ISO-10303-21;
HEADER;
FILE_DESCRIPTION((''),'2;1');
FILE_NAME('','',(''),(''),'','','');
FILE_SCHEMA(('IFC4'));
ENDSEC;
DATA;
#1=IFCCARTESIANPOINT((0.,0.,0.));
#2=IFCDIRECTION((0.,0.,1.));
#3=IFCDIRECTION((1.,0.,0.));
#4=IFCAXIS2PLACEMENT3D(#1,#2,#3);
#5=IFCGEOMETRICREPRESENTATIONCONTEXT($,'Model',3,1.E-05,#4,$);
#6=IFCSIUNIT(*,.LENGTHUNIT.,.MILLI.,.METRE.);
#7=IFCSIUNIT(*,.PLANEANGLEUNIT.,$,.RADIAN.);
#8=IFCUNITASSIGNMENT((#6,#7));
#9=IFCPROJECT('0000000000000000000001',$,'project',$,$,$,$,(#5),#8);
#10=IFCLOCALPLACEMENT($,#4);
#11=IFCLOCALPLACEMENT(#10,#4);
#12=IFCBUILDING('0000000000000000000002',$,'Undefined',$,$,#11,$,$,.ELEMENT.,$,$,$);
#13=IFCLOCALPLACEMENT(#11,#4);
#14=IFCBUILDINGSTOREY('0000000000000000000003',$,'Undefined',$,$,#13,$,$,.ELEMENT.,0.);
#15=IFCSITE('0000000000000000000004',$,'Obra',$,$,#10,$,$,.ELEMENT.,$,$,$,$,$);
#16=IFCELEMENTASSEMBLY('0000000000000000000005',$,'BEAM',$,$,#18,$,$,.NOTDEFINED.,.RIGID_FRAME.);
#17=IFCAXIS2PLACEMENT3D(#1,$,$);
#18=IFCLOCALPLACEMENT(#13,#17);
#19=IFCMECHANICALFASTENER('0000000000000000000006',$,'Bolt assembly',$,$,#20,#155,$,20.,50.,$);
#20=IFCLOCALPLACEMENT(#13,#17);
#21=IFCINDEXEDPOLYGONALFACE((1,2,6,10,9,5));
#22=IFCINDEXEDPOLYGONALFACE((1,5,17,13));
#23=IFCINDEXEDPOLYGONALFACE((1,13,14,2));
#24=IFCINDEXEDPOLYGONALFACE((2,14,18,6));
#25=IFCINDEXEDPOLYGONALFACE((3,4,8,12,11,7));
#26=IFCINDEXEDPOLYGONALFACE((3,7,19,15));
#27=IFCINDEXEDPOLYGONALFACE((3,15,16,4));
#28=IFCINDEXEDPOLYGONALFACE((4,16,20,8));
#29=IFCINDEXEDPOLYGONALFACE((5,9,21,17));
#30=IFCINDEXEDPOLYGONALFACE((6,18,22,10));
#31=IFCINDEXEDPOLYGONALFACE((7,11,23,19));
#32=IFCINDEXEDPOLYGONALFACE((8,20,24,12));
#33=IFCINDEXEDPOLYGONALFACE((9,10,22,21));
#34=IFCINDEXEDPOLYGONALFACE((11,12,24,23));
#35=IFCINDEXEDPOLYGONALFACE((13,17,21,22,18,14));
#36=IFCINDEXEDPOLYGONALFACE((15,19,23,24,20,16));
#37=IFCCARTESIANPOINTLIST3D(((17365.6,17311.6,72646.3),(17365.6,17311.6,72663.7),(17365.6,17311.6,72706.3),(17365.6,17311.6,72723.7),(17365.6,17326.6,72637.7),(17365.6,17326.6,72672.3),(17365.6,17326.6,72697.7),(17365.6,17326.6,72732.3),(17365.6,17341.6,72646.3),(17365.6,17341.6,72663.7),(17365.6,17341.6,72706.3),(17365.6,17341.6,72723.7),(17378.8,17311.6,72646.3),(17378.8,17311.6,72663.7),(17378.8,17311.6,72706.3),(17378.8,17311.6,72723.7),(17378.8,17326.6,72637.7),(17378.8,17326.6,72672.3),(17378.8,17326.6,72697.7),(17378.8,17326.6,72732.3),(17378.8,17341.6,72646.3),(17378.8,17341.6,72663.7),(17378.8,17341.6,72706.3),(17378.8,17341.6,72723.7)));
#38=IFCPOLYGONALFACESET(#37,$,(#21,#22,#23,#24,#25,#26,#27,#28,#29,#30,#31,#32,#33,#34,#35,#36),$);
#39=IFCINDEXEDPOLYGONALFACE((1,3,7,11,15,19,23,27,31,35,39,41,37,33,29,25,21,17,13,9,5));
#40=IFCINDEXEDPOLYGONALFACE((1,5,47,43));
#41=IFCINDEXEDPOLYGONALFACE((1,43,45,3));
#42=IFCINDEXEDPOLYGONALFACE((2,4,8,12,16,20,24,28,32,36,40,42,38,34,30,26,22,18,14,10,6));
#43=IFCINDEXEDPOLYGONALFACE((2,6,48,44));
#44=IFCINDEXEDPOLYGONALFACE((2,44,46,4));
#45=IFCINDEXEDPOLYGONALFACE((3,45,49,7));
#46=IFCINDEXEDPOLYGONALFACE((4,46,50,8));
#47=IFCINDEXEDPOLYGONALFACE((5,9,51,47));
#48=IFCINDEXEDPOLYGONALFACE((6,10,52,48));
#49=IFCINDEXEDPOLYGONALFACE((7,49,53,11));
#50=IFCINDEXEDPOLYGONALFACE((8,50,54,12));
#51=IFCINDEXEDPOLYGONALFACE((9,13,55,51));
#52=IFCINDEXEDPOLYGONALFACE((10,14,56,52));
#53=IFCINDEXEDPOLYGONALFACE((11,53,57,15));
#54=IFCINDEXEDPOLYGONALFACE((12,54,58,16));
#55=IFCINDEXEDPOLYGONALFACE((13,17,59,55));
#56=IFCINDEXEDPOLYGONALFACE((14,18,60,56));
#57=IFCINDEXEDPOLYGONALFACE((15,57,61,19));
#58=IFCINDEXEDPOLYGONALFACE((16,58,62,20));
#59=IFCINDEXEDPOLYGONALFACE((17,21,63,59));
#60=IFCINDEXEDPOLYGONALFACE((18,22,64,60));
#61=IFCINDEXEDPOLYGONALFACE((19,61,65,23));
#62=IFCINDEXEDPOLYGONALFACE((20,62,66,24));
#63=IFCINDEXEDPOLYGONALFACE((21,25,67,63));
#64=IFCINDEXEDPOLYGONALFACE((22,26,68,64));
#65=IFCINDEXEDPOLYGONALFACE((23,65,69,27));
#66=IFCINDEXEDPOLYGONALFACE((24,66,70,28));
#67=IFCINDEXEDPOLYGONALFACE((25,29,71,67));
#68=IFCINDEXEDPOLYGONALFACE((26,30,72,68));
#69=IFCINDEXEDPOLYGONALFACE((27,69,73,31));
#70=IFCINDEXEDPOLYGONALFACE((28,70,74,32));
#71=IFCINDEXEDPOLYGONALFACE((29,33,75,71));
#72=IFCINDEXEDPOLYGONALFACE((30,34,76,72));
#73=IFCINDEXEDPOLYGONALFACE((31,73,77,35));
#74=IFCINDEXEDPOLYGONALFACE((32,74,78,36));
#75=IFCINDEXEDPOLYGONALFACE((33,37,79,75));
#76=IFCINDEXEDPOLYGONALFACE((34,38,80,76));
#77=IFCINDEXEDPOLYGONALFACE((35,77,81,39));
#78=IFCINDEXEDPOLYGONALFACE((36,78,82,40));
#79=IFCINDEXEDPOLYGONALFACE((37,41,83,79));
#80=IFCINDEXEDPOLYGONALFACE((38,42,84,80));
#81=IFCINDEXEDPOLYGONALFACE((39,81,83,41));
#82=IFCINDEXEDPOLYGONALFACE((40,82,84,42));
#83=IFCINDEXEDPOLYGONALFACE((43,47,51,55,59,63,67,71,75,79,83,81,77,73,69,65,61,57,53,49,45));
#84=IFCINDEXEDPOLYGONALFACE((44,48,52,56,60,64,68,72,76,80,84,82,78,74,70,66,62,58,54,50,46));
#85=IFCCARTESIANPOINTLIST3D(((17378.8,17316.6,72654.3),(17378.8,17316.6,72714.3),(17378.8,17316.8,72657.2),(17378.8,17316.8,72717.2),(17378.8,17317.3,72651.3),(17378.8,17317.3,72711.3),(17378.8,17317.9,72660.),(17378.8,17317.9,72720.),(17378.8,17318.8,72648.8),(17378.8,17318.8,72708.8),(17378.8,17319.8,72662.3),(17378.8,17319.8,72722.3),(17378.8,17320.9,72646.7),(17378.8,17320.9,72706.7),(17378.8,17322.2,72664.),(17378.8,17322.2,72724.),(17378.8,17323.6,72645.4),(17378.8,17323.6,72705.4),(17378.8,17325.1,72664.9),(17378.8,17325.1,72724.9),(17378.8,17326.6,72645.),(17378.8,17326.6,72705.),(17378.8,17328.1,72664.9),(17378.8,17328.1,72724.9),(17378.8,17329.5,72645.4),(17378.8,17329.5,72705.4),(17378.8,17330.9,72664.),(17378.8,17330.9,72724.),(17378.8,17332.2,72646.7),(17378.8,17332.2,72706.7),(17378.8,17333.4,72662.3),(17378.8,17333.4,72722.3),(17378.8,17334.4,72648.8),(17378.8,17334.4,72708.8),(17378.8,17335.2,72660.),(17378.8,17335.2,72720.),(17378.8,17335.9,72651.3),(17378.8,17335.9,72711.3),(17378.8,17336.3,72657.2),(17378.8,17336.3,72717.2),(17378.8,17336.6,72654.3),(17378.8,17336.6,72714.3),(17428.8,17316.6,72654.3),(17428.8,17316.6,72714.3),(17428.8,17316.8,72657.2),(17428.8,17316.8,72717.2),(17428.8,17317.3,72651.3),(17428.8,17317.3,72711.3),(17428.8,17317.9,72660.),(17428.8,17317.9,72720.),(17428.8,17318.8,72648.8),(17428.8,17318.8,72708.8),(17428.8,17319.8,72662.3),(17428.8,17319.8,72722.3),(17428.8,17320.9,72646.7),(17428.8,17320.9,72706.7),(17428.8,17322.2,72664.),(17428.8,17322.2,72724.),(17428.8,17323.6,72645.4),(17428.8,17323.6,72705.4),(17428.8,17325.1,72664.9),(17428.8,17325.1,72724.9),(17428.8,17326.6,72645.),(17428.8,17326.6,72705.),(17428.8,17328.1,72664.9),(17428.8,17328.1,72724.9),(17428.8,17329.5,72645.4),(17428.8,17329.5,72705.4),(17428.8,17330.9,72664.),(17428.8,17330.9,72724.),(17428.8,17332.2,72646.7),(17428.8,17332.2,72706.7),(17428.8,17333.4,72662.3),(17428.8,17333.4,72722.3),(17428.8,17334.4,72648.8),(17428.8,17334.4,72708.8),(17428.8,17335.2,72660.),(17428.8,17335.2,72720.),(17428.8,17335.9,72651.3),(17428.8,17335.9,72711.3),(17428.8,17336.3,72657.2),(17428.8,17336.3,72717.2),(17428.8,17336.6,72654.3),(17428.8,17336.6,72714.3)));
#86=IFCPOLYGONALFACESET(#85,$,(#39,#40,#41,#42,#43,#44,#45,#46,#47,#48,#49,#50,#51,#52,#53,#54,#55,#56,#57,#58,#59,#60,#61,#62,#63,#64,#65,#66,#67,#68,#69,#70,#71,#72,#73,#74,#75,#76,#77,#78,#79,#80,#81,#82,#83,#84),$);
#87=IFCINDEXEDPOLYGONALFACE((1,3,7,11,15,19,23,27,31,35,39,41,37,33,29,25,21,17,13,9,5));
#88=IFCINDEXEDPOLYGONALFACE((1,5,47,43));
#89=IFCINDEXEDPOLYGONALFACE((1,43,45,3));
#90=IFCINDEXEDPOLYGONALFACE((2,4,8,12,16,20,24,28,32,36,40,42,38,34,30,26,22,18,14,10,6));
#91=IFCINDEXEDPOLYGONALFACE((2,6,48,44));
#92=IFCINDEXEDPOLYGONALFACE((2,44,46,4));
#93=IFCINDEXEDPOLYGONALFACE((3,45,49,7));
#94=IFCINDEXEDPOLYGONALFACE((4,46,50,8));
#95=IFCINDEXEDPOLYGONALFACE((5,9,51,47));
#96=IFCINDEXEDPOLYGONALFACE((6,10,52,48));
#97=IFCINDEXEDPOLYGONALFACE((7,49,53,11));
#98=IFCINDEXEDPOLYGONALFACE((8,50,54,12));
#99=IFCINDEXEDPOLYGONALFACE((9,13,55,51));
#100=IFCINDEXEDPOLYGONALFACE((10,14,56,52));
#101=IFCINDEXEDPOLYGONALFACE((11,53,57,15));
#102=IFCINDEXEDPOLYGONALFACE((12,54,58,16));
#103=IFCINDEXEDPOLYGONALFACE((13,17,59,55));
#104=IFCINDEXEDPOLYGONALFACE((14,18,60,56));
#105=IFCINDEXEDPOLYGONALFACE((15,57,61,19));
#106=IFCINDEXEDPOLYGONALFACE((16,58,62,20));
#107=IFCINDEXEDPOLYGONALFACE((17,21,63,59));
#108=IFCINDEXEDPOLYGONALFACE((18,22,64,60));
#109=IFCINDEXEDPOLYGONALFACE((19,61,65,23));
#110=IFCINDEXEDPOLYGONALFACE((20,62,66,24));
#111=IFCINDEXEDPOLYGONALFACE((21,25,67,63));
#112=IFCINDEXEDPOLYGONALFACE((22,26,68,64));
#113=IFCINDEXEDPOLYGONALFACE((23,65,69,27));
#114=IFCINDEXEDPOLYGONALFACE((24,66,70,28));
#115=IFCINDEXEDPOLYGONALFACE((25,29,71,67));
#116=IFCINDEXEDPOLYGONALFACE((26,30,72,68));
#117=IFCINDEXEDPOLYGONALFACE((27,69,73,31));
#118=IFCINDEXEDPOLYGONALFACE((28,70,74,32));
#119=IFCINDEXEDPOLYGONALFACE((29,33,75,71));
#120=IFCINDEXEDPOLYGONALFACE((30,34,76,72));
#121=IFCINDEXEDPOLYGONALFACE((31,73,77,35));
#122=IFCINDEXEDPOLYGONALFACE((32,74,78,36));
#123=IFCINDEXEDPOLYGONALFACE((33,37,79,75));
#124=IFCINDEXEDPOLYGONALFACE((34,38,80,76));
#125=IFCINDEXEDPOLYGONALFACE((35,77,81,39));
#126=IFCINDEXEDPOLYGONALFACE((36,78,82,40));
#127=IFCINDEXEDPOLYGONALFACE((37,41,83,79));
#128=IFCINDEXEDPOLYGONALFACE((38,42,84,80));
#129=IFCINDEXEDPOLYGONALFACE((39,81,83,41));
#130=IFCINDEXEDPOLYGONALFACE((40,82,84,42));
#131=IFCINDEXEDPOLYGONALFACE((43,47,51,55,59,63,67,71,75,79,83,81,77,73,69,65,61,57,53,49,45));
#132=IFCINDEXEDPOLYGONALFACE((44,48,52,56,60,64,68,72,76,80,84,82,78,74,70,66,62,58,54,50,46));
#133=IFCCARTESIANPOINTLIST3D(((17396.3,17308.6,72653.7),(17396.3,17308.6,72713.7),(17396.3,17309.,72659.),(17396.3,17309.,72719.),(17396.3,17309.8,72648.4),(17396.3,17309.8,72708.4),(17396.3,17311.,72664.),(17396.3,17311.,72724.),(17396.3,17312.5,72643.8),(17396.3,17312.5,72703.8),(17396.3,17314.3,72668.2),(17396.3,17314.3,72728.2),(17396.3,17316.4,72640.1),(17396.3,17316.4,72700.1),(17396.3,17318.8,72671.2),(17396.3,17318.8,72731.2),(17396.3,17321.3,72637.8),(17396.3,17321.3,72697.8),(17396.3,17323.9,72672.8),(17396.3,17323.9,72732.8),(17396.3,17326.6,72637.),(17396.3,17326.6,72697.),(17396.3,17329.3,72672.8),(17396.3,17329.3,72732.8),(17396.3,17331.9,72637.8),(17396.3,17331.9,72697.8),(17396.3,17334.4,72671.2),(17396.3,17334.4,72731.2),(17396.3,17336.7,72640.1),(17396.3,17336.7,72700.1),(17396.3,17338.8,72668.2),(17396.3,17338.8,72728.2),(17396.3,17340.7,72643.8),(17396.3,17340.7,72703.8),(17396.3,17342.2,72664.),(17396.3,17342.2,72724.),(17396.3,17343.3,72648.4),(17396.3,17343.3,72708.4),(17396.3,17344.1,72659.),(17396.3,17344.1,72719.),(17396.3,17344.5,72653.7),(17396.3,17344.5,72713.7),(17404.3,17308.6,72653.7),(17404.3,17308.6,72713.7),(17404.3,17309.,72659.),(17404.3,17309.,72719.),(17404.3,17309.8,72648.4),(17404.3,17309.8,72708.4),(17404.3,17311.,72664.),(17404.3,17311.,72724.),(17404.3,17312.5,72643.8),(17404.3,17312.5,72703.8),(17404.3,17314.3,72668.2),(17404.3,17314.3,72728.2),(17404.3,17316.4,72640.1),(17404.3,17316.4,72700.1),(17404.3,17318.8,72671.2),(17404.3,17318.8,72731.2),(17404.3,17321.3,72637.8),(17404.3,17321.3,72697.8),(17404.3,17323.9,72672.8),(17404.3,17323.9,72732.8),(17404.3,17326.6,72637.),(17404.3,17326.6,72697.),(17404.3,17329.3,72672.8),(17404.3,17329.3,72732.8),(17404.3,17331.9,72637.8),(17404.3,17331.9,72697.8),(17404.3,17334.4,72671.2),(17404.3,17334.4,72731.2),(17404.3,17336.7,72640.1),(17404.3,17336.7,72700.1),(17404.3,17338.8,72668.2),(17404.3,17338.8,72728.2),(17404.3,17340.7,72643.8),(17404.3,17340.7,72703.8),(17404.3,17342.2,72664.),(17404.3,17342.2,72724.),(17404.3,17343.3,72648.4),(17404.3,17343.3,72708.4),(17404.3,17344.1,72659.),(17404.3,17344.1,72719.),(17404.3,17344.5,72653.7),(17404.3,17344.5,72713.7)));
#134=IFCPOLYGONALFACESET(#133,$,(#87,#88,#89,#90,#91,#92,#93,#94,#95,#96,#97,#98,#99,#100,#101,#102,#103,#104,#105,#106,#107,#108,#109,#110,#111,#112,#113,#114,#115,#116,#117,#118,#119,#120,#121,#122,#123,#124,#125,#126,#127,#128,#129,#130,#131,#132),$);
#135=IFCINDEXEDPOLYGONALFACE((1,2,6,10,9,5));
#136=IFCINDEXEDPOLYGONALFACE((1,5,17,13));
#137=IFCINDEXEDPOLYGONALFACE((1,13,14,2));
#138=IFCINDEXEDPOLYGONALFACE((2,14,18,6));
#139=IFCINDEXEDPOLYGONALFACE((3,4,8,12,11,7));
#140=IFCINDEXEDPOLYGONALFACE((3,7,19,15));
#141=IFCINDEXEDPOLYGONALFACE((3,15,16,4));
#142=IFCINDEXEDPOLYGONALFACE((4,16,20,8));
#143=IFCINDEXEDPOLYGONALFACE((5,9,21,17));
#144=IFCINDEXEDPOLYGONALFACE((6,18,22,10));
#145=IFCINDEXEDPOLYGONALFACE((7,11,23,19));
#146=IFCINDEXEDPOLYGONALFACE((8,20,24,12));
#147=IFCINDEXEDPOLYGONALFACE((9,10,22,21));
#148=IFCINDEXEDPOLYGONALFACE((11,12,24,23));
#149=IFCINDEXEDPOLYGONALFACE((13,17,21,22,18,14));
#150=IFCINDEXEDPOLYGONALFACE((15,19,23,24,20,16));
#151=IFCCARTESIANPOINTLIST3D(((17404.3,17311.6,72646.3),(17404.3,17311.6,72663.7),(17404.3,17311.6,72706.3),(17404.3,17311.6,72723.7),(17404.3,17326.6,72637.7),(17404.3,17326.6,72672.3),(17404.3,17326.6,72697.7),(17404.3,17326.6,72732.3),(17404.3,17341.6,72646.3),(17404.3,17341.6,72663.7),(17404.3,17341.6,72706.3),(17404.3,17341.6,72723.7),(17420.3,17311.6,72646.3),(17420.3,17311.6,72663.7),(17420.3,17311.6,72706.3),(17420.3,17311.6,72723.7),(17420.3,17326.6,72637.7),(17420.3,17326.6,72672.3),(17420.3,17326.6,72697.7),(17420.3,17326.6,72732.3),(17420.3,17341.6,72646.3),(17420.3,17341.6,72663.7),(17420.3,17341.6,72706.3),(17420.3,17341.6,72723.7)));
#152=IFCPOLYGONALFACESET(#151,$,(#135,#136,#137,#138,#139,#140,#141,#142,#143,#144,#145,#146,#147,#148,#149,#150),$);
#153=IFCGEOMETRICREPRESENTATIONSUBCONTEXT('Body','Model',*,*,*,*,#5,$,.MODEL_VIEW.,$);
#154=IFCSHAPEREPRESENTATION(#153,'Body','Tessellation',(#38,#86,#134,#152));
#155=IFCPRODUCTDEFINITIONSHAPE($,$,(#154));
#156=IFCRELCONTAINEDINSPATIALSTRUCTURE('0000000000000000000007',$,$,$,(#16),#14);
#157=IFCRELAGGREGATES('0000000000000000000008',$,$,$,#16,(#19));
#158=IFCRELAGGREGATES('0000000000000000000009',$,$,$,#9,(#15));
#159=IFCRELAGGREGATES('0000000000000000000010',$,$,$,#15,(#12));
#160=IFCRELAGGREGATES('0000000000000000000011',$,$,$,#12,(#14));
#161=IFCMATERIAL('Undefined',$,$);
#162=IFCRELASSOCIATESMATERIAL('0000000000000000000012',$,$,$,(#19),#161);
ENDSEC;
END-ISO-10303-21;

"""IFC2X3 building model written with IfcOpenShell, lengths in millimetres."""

from ifc_helpers import new_model, si_unit, frame, origin_with_axes, origin_2d_with_axis, place, context, subcontext, project, spatial, polyline, circle, outline, extrude, source, transform, mapped, material, element, aggregate, save


model = new_model("IFC2X3")

# Units and contexts
model_context = context("Model", 3, precision=1e-05, world=origin_with_axes())
body_context = subcontext(model_context, "Body", "Model", "MODEL_VIEW")
ifc_project = project(units=[si_unit("LENGTHUNIT", "METRE", prefix="MILLI"), si_unit("PLANEANGLEUNIT", "RADIAN")], contexts=[model_context])

# Site, building, storey
site_placement = place(None, origin_with_axes())
site = spatial("IfcSite", under=ifc_project, at=site_placement, Name="Obra", CompositionType="ELEMENT")
building_placement = place(site_placement, origin_with_axes())
building = spatial("IfcBuilding", under=site, at=building_placement, Name="Undefined", CompositionType="ELEMENT")
storey_placement = place(building_placement, origin_with_axes())
storey = spatial("IfcBuildingStorey", under=building, at=storey_placement, Name="Undefined", CompositionType="ELEMENT", Elevation=0.0)

# Shared definitions
ifc_material = material(Name="Undefined")

# Shared definitions
shared_shape_1 = source(origin_with_axes(), body_context, "Body", "SweptSolid", [
    extrude(outline(polyline([(17.3, 0.0), (8.7, 15.0), (-8.7, 15.0), (-17.3, 0.0), (-8.7, -15.0), (8.7, -15.0), (17.3, 0.0)])), frame((0.0, -27.0, 0.0), z_axis=(0.0, 1.0, 0.0), x_axis=(1.0, 0.0, 0.0)), (0.0, 0.0, 1.0), 13.2),
    extrude(circle(Radius=10.0, at=origin_2d_with_axis()), frame((0.0, -13.8, 0.0), z_axis=(0.0, 1.0, 0.0), x_axis=(1.0, 0.0, 0.0)), (0.0, 0.0, 1.0), 50.0),
    extrude(circle(Radius=18.0, at=origin_2d_with_axis()), frame((0.0, 3.7, 0.0), z_axis=(0.0, 1.0, 0.0), x_axis=(1.0, 0.0, 0.0)), (0.0, 0.0, 1.0), 8.0),
    extrude(outline(polyline([(17.3, 0.0), (8.7, 15.0), (-8.7, 15.0), (-17.3, 0.0), (-8.7, -15.0), (8.7, -15.0), (17.3, 0.0)])), frame((0.0, 11.7, 0.0), z_axis=(0.0, 1.0, 0.0), x_axis=(1.0, 0.0, 0.0)), (0.0, 0.0, 1.0), 16.0),
])

# Element assembly, mechanical fastener
assembly_1_placement = place(storey_placement, origin_with_axes())
assembly_1 = element("IfcElementAssembly", 1, at=assembly_1_placement, inside=storey, Name="BEAM", AssemblyPlace="NOTDEFINED", PredefinedType="RIGID_FRAME")
mechanical_fastener_1_placement = place(assembly_1_placement, frame((17392.6, 17366.6, 72850.0), z_axis=(0.0, -1.0, 0.0), x_axis=(0.0, 0.0, -1.0)))
mechanical_fastener_1 = element("IfcMechanicalFastener", 2, at=mechanical_fastener_1_placement, material=ifc_material, Name="Bolt assembly", NominalDiameter=20.0, NominalLength=50.0, context=body_context, shape_type="MappedRepresentation", body=[
    mapped(shared_shape_1, transform((135.0, 0.0, 40.0))),
    mapped(shared_shape_1, transform((195.0, 0.0, 40.0))),
])
aggregate(assembly_1, [mechanical_fastener_1])

save(model, "model.ifc")
